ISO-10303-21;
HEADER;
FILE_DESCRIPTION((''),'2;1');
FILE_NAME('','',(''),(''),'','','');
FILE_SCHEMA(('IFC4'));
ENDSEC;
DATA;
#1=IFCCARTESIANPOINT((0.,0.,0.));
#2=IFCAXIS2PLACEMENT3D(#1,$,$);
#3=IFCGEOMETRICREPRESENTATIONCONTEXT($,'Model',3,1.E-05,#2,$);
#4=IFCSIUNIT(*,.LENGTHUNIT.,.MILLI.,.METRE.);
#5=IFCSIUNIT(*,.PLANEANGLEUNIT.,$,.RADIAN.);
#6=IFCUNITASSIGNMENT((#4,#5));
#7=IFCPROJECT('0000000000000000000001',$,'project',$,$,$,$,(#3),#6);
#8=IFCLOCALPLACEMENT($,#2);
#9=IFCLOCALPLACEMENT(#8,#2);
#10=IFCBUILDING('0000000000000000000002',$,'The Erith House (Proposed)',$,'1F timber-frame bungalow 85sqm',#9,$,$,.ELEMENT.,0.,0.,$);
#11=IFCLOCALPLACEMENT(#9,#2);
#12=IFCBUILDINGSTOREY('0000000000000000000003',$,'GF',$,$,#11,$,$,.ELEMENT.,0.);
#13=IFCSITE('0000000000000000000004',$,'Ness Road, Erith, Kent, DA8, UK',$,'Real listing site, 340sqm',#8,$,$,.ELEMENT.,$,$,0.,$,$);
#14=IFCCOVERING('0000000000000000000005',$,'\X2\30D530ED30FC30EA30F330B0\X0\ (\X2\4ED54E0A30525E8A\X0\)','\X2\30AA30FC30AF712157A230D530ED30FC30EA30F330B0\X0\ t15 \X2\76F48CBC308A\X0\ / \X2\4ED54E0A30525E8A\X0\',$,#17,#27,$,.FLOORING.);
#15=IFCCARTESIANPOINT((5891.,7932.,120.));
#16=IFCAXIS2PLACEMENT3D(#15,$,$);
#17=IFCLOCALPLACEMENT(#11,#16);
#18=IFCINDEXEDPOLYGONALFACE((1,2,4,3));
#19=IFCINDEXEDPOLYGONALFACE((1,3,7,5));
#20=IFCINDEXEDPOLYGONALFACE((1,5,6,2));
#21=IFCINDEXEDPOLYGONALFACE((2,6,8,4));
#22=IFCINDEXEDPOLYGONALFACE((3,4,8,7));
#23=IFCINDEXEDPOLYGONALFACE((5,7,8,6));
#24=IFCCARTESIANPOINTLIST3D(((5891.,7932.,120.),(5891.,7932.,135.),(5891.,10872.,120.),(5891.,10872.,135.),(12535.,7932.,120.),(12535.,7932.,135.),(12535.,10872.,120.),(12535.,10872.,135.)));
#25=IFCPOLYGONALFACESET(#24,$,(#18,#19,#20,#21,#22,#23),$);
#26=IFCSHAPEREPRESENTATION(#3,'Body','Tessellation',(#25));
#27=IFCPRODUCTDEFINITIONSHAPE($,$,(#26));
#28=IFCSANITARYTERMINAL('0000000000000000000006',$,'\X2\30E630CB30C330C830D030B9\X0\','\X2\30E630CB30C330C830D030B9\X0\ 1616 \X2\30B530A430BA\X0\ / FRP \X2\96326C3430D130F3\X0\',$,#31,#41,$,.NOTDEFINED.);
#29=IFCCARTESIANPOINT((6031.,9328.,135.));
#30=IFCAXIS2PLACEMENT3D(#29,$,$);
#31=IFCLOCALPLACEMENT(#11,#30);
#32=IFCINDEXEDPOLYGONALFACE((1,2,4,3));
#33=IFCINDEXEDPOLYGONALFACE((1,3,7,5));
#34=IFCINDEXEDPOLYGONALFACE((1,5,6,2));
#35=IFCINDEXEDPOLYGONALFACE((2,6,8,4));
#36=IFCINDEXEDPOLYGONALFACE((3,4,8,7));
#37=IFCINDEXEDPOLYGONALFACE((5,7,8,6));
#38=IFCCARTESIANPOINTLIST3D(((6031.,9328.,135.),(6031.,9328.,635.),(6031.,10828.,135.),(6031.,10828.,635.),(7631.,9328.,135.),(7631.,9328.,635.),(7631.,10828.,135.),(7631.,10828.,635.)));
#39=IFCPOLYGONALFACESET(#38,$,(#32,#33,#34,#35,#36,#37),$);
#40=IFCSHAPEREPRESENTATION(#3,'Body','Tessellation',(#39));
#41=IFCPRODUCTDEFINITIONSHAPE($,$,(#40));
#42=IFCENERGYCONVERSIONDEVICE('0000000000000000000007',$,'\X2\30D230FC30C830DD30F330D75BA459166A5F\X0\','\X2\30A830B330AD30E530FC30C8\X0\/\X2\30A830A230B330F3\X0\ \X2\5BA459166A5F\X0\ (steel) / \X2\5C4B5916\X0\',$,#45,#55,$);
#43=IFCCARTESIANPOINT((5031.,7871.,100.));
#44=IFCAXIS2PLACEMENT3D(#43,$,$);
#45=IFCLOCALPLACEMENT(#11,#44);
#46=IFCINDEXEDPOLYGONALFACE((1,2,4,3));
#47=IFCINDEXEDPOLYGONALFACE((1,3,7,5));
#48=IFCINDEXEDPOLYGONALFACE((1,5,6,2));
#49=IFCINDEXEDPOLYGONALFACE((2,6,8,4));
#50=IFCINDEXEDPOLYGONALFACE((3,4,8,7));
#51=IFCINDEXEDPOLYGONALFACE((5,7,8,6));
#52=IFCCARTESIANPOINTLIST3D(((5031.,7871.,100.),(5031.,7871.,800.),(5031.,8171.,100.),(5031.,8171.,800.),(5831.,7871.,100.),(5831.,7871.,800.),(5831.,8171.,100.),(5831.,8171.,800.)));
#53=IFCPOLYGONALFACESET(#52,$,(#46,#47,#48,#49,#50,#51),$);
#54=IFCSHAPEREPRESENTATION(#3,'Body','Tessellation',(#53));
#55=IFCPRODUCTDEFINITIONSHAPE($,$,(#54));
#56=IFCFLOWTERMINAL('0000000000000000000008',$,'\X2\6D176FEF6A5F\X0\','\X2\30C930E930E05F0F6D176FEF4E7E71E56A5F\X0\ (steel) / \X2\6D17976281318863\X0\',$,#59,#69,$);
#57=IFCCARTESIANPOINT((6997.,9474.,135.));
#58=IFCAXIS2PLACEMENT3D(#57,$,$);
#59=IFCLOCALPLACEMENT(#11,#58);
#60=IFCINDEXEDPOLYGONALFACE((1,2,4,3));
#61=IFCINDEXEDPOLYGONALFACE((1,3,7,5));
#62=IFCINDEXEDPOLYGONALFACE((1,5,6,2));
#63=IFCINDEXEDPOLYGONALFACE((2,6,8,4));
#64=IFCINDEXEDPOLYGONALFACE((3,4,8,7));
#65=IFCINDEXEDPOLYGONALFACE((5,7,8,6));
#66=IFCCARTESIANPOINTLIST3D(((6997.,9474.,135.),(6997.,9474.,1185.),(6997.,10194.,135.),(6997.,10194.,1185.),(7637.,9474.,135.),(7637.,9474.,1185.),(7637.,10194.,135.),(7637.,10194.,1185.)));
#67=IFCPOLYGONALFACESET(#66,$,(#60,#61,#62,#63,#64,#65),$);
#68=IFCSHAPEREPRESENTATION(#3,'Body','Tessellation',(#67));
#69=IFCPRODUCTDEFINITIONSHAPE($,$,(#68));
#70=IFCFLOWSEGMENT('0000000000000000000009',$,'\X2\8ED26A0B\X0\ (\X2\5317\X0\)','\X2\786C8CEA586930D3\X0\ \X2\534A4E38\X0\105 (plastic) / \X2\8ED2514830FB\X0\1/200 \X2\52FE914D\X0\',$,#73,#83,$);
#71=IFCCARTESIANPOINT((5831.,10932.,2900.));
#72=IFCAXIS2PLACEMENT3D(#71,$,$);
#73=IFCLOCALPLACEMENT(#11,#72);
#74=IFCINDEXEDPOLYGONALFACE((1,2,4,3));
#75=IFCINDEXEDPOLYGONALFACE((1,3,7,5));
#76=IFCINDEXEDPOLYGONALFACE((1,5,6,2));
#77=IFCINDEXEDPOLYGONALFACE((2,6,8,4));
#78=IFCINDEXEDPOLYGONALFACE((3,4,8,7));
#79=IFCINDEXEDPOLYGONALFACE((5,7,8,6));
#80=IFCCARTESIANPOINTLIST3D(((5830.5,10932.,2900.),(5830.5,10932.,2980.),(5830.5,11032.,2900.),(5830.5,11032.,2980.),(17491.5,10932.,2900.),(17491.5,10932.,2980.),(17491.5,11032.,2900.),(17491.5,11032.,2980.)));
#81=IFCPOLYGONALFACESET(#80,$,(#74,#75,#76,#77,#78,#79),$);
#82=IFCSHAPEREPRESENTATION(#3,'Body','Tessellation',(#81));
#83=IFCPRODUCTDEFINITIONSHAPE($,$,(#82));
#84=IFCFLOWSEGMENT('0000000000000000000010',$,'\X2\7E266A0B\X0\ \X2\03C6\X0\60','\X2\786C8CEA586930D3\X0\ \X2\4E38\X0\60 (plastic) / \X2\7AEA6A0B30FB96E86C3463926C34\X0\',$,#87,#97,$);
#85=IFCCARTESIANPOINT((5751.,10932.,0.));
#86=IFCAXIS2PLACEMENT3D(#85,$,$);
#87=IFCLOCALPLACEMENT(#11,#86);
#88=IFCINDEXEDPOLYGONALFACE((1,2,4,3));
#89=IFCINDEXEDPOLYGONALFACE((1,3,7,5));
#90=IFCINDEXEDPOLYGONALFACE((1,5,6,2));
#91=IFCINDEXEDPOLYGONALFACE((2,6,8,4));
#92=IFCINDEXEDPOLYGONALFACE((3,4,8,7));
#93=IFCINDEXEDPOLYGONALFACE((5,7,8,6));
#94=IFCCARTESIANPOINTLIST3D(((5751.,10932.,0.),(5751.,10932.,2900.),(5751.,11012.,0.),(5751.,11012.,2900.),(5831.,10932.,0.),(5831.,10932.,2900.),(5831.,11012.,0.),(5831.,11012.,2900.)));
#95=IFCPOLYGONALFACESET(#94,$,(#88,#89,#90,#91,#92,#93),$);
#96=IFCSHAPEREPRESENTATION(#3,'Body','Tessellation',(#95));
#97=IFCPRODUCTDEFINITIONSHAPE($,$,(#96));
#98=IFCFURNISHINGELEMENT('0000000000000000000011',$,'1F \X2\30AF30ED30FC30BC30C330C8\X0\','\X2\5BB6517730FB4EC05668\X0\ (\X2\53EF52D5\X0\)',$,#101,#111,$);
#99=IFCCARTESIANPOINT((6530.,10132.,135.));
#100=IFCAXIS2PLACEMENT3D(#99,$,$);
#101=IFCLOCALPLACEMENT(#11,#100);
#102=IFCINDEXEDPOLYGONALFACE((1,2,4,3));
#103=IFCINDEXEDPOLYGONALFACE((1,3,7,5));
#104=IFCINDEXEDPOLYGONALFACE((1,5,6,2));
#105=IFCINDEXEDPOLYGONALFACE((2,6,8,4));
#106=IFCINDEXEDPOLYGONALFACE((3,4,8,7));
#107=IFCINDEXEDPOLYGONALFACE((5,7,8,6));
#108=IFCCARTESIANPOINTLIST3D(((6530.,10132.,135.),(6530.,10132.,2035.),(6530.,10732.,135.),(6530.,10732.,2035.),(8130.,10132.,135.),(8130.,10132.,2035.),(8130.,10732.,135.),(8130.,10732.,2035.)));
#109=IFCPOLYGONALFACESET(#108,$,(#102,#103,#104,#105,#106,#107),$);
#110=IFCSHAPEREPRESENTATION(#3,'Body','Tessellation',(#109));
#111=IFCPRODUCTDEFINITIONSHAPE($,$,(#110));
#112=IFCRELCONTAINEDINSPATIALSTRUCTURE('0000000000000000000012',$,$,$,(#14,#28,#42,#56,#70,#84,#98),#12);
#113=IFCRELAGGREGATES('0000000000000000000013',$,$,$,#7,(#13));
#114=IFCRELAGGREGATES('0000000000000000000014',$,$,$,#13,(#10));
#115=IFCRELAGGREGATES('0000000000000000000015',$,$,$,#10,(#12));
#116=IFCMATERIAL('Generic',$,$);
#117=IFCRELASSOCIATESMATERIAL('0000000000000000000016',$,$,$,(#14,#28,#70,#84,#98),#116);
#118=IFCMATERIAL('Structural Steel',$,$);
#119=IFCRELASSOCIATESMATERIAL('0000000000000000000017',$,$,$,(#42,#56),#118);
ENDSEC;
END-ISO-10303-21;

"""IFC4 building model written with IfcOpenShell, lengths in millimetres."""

from ifc_helpers import new_model, si_unit, frame, frame_2d, origin, place, context, project, spatial, rectangle, extrude, material, element, save


model = new_model("IFC4")

# Units and contexts
model_context = context("Model", 3, precision=1e-05, world=origin())
ifc_project = project(units=[si_unit("LENGTHUNIT", "METRE", prefix="MILLI"), si_unit("PLANEANGLEUNIT", "RADIAN")], contexts=[model_context])

# Site, building, storey
site_placement = place(None, origin())
site = spatial("IfcSite", under=ifc_project, at=site_placement, Name="Ness Road, Erith, Kent, DA8, UK", ObjectType="Real listing site, 340sqm", CompositionType="ELEMENT", RefElevation=0.0)
building_placement = place(site_placement, origin())
building = spatial("IfcBuilding", under=site, at=building_placement, Name="The Erith House (Proposed)", ObjectType="1F timber-frame bungalow 85sqm", CompositionType="ELEMENT", ElevationOfRefHeight=0.0, ElevationOfTerrain=0.0)
storey_placement = place(building_placement, origin())
storey = spatial("IfcBuildingStorey", under=building, at=storey_placement, Name="GF", CompositionType="ELEMENT", Elevation=0.0)

# Shared definitions
ifc_material_1 = material(Name="Structural Steel")

# Covering
ifc_material_2 = material(Name="Generic")
covering_placement = place(storey_placement, frame((5891.0, 7932.0, 120.0)))
element("IfcCovering", 1, at=covering_placement, inside=storey, material=ifc_material_2, Name="フローリング (仕上げ床)", Description="オーク無垢フローリング t15 直貼り / 仕上げ床", PredefinedType="FLOORING", context=model_context, shape_type="SweptSolid", body=[
    extrude(rectangle(XDim=6644.0, YDim=2940.0, at=frame_2d((3322.0, 1470.0))), frame((5891.0, 7932.0, 120.0)), (0.0, 0.0, 1.0), 15.0),
])

# Sanitary terminal
sanitary_terminal_placement = place(storey_placement, frame((6031.0, 9328.0, 135.0)))
element("IfcSanitaryTerminal", 2, at=sanitary_terminal_placement, inside=storey, material=ifc_material_2, Name="ユニットバス", Description="ユニットバス 1616 サイズ / FRP 防水パン", PredefinedType="NOTDEFINED", context=model_context, shape_type="SweptSolid", body=[
    extrude(rectangle(XDim=1600.0, YDim=1500.0, at=frame_2d((800.0, 750.0))), frame((6031.0, 9328.0, 135.0)), (0.0, 0.0, 1.0), 500.0),
])

# Energy conversion device
energy_conversion_device_placement = place(storey_placement, frame((5031.0, 7871.0, 100.0)))
element("IfcEnergyConversionDevice", 3, at=energy_conversion_device_placement, inside=storey, material=ifc_material_1, Name="ヒートポンプ室外機", Description="エコキュート/エアコン 室外機 (steel) / 屋外", context=model_context, shape_type="SweptSolid", body=[
    extrude(rectangle(XDim=800.0, YDim=300.0, at=frame_2d((400.0, 150.0))), frame((5031.0, 7871.0, 100.0)), (0.0, 0.0, 1.0), 700.0),
])

# Flow terminal
flow_terminal_placement = place(storey_placement, frame((6997.0, 9474.0, 135.0)))
element("IfcFlowTerminal", 4, at=flow_terminal_placement, inside=storey, material=ifc_material_1, Name="洗濯機", Description="ドラム式洗濯乾燥機 (steel) / 洗面脱衣", context=model_context, shape_type="SweptSolid", body=[
    extrude(rectangle(XDim=640.0, YDim=720.0, at=frame_2d((320.0, 360.0))), frame((6997.0, 9474.0, 135.0)), (0.0, 0.0, 1.0), 1050.0),
])

# Flow segments
flow_segment_1_placement = place(storey_placement, frame((5831.0, 10932.0, 2900.0)))
element("IfcFlowSegment", 5, at=flow_segment_1_placement, inside=storey, material=ifc_material_2, Name="軒樋 (北)", Description="硬質塩ビ 半丸105 (plastic) / 軒先・1/200 勾配", context=model_context, shape_type="SweptSolid", body=[
    extrude(rectangle(XDim=11661.0, YDim=100.0, at=frame_2d((5830.0, 50.0))), frame((5831.0, 10932.0, 2900.0)), (0.0, 0.0, 1.0), 80.0),
])
flow_segment_2_placement = place(storey_placement, frame((5751.0, 10932.0, 0.0)))
element("IfcFlowSegment", 6, at=flow_segment_2_placement, inside=storey, material=ifc_material_2, Name="縦樋 φ60", Description="硬質塩ビ 丸60 (plastic) / 竪樋・雨水排水", context=model_context, shape_type="SweptSolid", body=[
    extrude(rectangle(XDim=80.0, YDim=80.0, at=frame_2d((40.0, 40.0))), frame((5751.0, 10932.0, 0.0)), (0.0, 0.0, 1.0), 2900.0),
])

# Furnishing element
furnishing_placement = place(storey_placement, frame((6530.0, 10132.0, 135.0)))
element("IfcFurnishingElement", 7, at=furnishing_placement, inside=storey, material=ifc_material_2, Name="1F クローゼット", Description="家具・什器 (可動)", context=model_context, shape_type="SweptSolid", body=[
    extrude(rectangle(XDim=1600.0, YDim=600.0, at=frame_2d((800.0, 300.0))), frame((6530.0, 10132.0, 135.0)), (0.0, 0.0, 1.0), 1900.0),
])

save(model, "model.ifc")
